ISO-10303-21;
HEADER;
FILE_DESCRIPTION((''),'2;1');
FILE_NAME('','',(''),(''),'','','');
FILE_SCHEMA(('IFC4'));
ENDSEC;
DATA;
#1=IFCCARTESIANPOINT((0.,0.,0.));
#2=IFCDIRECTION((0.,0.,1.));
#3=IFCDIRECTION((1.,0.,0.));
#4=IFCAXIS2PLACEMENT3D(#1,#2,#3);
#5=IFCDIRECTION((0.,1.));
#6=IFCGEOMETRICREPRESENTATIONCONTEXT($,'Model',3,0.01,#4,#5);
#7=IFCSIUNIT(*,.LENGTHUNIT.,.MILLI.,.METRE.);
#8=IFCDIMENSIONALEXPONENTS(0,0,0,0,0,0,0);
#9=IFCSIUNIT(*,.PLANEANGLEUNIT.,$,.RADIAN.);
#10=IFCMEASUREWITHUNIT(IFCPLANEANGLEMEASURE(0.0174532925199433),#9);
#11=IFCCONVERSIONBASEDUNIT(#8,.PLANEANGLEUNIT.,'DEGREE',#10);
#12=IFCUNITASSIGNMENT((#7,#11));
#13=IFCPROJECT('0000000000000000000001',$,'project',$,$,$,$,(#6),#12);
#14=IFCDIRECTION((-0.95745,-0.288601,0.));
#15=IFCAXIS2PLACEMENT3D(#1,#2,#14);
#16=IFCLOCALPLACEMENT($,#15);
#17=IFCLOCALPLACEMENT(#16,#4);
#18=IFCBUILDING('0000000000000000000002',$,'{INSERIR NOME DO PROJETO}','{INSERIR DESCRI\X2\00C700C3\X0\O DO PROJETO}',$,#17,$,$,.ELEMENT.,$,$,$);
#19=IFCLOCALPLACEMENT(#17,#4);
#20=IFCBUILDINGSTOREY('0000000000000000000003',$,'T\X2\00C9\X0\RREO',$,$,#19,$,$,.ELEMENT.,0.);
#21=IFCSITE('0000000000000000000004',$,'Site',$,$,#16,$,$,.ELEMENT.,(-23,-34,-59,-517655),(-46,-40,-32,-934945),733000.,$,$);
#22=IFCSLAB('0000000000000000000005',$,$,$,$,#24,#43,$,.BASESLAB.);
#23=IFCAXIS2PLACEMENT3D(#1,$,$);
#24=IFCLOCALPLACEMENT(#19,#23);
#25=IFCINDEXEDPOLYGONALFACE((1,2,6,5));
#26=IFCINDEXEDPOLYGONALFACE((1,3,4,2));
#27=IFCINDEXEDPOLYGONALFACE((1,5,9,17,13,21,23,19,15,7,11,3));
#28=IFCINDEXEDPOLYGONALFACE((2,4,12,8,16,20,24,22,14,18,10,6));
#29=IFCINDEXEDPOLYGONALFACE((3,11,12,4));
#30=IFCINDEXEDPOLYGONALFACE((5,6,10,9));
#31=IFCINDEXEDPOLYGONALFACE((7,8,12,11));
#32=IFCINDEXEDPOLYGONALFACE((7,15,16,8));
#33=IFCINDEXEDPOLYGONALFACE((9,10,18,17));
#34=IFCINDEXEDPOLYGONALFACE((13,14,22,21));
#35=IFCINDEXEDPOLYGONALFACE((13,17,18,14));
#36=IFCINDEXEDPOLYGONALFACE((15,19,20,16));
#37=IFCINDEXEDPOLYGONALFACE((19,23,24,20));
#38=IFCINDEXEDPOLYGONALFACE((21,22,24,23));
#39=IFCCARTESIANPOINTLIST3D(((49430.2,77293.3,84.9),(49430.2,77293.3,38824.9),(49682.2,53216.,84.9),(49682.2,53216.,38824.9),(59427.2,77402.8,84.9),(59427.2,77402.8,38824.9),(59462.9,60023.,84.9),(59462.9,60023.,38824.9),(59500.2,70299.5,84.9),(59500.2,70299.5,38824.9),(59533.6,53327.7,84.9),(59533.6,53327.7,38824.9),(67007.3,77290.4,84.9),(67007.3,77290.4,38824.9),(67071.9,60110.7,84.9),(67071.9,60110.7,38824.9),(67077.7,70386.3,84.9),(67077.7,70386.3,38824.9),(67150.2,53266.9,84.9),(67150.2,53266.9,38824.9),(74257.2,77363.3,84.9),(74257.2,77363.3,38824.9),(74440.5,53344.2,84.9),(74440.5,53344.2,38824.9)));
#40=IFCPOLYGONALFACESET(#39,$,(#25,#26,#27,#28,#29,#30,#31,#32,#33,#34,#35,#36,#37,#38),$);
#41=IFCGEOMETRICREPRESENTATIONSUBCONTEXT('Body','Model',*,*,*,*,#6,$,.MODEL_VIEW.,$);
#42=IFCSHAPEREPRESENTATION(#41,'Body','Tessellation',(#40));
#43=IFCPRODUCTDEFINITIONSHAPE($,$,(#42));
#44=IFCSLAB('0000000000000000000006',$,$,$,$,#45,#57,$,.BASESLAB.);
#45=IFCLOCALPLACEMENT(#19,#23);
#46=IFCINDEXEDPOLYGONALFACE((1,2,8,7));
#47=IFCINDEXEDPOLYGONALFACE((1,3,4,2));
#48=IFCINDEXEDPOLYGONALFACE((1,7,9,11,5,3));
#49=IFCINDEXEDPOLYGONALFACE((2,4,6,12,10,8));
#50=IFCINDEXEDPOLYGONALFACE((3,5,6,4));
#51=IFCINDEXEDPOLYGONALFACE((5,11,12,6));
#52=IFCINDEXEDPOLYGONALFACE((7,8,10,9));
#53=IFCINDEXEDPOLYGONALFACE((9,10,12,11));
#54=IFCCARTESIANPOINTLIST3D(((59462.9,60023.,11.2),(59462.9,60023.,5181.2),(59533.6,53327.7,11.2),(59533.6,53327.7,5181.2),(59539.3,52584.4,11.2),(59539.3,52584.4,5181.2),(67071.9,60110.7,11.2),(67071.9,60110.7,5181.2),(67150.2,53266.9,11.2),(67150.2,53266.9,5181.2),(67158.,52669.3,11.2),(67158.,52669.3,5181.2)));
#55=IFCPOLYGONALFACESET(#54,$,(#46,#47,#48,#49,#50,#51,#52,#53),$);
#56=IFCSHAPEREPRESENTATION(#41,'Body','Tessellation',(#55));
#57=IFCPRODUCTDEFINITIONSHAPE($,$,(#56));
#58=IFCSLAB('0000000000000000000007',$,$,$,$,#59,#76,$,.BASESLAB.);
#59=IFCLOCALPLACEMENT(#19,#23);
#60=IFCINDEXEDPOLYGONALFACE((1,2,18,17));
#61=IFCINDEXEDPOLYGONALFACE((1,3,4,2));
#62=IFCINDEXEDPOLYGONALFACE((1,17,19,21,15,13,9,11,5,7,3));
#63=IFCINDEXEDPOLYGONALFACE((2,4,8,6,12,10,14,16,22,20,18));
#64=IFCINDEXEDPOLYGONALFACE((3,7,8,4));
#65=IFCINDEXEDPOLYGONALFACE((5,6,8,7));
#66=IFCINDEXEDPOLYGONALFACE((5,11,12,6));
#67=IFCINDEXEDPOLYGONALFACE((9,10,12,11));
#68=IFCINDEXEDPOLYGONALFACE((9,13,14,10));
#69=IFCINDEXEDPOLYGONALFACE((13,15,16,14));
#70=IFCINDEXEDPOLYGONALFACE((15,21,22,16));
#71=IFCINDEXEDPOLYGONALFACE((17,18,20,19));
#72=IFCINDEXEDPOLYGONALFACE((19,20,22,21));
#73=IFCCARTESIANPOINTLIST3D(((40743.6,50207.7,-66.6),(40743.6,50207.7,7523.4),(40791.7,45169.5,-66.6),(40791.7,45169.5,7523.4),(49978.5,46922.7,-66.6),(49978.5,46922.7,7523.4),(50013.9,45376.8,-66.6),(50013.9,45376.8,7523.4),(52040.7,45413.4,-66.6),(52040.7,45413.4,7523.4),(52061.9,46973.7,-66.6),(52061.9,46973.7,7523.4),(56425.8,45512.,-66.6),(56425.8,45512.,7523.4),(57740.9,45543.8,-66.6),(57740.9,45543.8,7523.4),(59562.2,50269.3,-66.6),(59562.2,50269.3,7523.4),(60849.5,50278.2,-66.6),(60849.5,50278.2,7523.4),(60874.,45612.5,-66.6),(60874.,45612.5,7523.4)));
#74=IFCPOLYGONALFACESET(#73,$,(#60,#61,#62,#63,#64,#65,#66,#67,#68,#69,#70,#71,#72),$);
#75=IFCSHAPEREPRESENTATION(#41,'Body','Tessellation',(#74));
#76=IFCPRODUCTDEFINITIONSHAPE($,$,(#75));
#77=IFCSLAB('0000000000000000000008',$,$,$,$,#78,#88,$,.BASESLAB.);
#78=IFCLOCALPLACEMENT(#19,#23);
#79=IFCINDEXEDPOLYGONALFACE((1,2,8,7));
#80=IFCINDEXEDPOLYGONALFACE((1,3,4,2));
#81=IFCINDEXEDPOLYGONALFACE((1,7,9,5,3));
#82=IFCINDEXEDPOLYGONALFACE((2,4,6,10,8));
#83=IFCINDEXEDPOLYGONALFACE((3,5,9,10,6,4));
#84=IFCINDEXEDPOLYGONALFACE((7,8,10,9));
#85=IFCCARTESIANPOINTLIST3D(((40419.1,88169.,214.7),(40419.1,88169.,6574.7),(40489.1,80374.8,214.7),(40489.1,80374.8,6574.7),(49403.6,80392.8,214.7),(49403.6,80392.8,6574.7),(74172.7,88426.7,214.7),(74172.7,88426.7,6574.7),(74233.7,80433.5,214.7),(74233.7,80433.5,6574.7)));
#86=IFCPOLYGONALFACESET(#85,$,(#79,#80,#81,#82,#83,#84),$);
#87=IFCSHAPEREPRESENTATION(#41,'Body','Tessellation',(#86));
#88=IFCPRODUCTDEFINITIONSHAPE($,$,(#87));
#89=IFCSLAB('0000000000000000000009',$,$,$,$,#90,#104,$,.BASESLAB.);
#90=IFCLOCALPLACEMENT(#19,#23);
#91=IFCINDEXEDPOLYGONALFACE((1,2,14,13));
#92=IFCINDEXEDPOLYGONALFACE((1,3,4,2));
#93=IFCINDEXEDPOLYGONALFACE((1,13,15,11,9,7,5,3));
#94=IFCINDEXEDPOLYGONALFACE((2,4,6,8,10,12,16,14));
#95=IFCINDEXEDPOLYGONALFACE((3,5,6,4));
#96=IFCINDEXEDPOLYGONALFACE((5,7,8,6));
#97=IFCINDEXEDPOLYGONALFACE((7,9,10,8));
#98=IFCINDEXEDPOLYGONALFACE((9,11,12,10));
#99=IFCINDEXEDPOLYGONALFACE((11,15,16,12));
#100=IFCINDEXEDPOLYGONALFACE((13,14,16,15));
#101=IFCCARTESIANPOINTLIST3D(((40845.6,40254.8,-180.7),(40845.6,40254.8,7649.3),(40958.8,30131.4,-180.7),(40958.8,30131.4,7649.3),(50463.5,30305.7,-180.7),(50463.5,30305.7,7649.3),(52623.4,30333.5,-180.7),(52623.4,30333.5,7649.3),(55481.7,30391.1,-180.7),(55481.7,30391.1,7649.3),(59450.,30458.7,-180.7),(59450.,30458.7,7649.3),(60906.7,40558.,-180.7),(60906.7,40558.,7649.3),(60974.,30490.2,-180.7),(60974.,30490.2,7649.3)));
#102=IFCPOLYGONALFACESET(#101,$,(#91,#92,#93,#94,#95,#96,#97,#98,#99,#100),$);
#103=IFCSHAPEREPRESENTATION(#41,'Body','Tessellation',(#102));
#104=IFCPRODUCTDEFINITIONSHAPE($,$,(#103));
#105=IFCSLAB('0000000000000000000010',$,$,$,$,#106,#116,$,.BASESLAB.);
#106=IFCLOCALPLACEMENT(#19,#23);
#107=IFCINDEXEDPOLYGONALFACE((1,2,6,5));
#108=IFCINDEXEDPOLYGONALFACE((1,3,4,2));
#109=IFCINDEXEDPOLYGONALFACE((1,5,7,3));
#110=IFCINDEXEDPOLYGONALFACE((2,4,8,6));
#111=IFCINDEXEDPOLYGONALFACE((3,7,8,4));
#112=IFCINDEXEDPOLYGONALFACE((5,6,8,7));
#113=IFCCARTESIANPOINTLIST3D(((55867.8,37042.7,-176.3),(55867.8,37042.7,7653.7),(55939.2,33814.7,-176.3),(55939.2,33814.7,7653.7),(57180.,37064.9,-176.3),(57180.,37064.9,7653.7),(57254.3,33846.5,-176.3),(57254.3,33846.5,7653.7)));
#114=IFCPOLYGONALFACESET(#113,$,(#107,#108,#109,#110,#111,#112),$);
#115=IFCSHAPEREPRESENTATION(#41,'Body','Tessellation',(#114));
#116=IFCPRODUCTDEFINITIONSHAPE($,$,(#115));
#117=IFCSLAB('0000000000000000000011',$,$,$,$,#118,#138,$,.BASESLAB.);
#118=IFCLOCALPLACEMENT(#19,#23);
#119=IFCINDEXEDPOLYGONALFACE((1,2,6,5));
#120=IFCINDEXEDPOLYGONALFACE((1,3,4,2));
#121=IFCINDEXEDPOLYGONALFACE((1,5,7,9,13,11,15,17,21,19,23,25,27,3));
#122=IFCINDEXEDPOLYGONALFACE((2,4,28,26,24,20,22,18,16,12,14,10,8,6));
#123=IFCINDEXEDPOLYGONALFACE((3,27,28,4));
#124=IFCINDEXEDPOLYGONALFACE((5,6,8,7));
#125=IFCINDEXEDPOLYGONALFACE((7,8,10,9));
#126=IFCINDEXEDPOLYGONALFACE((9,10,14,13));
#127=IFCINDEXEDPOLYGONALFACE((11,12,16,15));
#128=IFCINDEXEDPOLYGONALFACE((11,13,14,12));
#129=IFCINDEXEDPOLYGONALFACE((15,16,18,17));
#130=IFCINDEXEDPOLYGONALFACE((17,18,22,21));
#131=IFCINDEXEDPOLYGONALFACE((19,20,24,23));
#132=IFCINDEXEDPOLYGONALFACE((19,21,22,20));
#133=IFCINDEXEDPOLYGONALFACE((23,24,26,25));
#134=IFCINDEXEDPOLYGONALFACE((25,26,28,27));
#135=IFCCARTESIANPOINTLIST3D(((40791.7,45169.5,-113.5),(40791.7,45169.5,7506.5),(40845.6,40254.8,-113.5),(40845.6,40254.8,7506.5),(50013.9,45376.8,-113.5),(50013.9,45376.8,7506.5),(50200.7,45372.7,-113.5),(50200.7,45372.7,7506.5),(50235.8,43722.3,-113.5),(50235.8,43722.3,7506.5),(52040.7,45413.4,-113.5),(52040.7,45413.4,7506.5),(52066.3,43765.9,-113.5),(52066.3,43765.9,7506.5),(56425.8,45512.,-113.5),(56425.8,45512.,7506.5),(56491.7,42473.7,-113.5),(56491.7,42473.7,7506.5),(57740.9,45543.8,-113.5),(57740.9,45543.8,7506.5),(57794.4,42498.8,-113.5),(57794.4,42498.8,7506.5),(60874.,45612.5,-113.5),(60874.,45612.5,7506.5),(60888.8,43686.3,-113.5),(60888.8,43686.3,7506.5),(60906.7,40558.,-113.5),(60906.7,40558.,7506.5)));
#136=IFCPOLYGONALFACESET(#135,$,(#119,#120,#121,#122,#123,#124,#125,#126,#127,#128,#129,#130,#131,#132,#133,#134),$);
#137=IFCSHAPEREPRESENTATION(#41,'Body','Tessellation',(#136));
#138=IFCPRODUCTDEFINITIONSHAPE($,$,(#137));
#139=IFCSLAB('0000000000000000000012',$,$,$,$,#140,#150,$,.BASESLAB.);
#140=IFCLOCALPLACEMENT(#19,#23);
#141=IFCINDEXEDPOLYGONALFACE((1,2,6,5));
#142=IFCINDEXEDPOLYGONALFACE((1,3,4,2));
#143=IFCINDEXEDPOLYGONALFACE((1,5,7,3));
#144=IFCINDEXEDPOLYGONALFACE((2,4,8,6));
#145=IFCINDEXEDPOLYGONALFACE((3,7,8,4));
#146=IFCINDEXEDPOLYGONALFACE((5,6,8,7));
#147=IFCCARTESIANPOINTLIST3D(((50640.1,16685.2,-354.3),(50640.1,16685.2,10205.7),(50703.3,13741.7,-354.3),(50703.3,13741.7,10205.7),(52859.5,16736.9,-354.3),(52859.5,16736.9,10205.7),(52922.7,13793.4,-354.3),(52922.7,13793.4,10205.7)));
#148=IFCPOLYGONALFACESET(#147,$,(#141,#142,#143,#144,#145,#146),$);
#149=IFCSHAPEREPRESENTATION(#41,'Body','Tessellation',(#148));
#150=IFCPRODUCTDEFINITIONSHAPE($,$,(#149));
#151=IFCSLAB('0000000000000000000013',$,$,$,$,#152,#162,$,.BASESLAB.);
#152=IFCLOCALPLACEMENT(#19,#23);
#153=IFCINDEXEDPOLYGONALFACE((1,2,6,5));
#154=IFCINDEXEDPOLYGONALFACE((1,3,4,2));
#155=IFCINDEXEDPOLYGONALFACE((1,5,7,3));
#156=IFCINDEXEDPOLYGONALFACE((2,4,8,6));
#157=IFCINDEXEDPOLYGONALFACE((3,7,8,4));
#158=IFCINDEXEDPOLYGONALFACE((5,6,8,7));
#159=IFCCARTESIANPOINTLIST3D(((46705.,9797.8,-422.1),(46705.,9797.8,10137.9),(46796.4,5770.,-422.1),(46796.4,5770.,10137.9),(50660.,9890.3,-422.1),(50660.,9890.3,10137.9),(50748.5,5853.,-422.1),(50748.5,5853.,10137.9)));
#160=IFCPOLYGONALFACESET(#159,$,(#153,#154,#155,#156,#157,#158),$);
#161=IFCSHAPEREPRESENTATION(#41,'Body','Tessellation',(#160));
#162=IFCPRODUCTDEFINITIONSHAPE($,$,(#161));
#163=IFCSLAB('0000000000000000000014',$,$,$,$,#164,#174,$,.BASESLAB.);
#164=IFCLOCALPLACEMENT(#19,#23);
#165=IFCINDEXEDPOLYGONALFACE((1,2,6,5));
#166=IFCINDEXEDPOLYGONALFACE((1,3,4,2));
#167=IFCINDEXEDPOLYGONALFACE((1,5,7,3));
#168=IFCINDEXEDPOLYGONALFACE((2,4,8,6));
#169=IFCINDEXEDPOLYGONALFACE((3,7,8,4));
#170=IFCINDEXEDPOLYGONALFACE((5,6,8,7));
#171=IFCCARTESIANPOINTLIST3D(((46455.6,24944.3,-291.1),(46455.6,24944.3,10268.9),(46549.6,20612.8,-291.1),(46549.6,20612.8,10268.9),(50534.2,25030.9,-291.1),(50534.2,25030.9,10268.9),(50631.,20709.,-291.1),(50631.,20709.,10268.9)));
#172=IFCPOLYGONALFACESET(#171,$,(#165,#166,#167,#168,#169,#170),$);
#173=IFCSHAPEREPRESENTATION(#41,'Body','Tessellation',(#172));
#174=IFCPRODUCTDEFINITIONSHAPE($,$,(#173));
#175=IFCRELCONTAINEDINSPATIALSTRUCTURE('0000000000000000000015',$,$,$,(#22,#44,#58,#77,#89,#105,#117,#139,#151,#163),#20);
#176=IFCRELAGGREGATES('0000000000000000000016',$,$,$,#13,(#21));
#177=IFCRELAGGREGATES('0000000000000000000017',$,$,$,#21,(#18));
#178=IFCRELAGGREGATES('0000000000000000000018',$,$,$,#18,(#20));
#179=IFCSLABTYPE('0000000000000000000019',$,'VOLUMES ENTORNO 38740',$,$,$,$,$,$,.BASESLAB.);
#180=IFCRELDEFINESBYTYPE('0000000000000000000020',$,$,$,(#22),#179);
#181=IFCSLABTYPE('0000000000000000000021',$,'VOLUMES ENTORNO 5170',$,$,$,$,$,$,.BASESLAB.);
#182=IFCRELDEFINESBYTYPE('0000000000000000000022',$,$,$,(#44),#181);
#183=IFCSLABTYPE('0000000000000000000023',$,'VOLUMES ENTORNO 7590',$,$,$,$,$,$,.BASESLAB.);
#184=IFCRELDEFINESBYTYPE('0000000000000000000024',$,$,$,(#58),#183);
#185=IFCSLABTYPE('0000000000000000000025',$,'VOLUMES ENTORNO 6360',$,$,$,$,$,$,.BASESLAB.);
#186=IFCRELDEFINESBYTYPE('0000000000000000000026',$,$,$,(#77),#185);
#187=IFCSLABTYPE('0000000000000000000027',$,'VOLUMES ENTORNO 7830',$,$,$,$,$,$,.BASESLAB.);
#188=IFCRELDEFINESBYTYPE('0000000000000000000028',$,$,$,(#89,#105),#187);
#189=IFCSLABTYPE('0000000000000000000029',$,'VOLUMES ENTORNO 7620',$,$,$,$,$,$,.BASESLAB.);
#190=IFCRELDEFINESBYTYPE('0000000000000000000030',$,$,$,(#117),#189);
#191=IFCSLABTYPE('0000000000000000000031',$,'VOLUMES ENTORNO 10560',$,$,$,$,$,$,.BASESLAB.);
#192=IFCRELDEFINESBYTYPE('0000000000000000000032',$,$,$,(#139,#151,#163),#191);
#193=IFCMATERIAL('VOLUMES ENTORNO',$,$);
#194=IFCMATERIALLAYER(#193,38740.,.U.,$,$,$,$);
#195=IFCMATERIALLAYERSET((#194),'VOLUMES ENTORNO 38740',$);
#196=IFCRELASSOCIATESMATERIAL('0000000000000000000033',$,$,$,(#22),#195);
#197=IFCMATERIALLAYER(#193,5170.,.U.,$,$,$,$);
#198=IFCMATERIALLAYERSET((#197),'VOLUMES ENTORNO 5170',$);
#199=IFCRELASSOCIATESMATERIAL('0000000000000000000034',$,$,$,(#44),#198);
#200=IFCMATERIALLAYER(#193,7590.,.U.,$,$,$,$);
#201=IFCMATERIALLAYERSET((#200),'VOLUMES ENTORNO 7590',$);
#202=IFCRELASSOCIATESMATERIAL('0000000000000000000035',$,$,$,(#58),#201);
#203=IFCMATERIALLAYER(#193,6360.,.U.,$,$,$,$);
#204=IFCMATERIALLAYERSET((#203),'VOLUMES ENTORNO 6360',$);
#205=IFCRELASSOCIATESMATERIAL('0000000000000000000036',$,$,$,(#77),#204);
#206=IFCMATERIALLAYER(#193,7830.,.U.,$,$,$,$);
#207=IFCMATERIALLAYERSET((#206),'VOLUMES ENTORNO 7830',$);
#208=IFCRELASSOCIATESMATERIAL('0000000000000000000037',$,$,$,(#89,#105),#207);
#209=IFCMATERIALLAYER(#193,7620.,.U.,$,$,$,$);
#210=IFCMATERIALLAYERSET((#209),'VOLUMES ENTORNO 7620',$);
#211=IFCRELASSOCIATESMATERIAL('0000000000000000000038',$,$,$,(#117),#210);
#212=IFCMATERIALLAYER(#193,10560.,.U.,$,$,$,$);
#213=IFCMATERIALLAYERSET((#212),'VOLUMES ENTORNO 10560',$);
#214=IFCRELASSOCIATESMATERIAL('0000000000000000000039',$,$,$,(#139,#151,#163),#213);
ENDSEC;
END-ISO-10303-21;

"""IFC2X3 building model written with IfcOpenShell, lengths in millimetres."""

from ifc_helpers import new_model, entity, si_unit, converted_unit, direction, frame, origin_with_axes, place, context, subcontext, project, spatial, polyline, outline, extrude, material, layer, layer_set, layer_usage, type_object, element, save


model = new_model("IFC2X3")

# Units and contexts
model_context = context("Model", 3, precision=0.01, world=origin_with_axes(), true_north=direction((0.0, 1.0)))
body_context = subcontext(model_context, "Body", "Model", "MODEL_VIEW")
ifc_project = project(units=[si_unit("LENGTHUNIT", "METRE", prefix="MILLI"), converted_unit("PLANEANGLEUNIT", "DEGREE", entity("IfcPlaneAngleMeasure", 0.0174532925199433), si_unit("PLANEANGLEUNIT", "RADIAN"), dimensions=[0, 0, 0, 0, 0, 0, 0])], contexts=[model_context])

# Site, building, storey
site_placement = place(None, frame((0.0, 0.0, 0.0), z_axis=(0.0, 0.0, 1.0), x_axis=(-0.95745, -0.288601, 0.0)))
site = spatial("IfcSite", under=ifc_project, at=site_placement, Name="Site", CompositionType="ELEMENT", RefLatitude=(-23, -34, -59, -517655), RefLongitude=(-46, -40, -32, -934945), RefElevation=733000.0)
building_placement = place(site_placement, origin_with_axes())
building = spatial("IfcBuilding", under=site, at=building_placement, Name="{INSERIR NOME DO PROJETO}", Description="{INSERIR DESCRIÇÃO DO PROJETO}", CompositionType="ELEMENT")
storey_placement = place(building_placement, origin_with_axes())
storey = spatial("IfcBuildingStorey", under=building, at=storey_placement, Name="TÉRREO", CompositionType="ELEMENT", Elevation=0.0)

# Slabs
ifc_material_1 = material(Name="VOLUMES ENTORNO")
ifc_layer_1 = layer(ifc_material_1, 38740.0, ventilated="UNKNOWN")
ifc_layer_set_1 = layer_set([ifc_layer_1], Name="VOLUMES ENTORNO 38740")
ifc_layer_usage_1 = layer_usage(ifc_layer_set_1, "AXIS3", "NEGATIVE", 38740.0)
slab_type_1 = type_object("IfcSlabType", Name="VOLUMES ENTORNO 38740", PredefinedType="BASESLAB")
slab_1_placement = place(storey_placement, frame((67071.9, 60110.7, 84.9), z_axis=(0.0, 0.0, 1.0), x_axis=(1.0, 0.0, 0.0)))
element("IfcSlab", 1, at=slab_1_placement, inside=storey, type_object=slab_type_1, material=ifc_layer_usage_1, PredefinedType="BASESLAB", context=body_context, shape_type="SweptSolid", body=[
    extrude(outline(polyline([(0.0, 0.0), (78.2, -6843.8), (7368.6, -6766.5), (7185.2, 17252.6), (-64.7, 17179.7), (5.8, 10275.6), (-7571.7, 10188.7), (-7644.8, 17292.1), (-17641.8, 17182.6), (-17389.8, -6894.7), (-7538.4, -6783.0), (-7609.1, -87.7), (0.0, 0.0)])), origin_with_axes(), (0.0, 0.0, 1.0), 38740.0),
])
ifc_layer_2 = layer(ifc_material_1, 5170.0, ventilated="UNKNOWN")
ifc_layer_set_2 = layer_set([ifc_layer_2], Name="VOLUMES ENTORNO 5170")
ifc_layer_usage_2 = layer_usage(ifc_layer_set_2, "AXIS3", "NEGATIVE", 5170.0)
slab_type_2 = type_object("IfcSlabType", Name="VOLUMES ENTORNO 5170", PredefinedType="BASESLAB")
slab_2_placement = place(storey_placement, frame((67071.9, 60110.7, 11.2), z_axis=(0.0, 0.0, 1.0), x_axis=(1.0, 0.0, 0.0)))
element("IfcSlab", 2, at=slab_2_placement, inside=storey, type_object=slab_type_2, material=ifc_layer_usage_2, PredefinedType="BASESLAB", context=body_context, shape_type="SweptSolid", body=[
    extrude(outline(polyline([(0.0, 0.0), (-7609.1, -87.7), (-7538.4, -6783.0), (-7532.6, -7526.3), (86.0, -7441.5), (78.2, -6843.8), (0.0, 0.0)])), origin_with_axes(), (0.0, 0.0, 1.0), 5170.0),
])
ifc_layer_3 = layer(ifc_material_1, 7590.0, ventilated="UNKNOWN")
ifc_layer_set_3 = layer_set([ifc_layer_3], Name="VOLUMES ENTORNO 7590")
ifc_layer_usage_3 = layer_usage(ifc_layer_set_3, "AXIS3", "NEGATIVE", 7590.0)
slab_type_3 = type_object("IfcSlabType", Name="VOLUMES ENTORNO 7590", PredefinedType="BASESLAB")
slab_3_placement = place(storey_placement, frame((50013.9, 45376.8, -66.6), z_axis=(0.0, 0.0, 1.0), x_axis=(1.0, 0.0, 0.0)))
element("IfcSlab", 3, at=slab_3_placement, inside=storey, type_object=slab_type_3, material=ifc_layer_usage_3, PredefinedType="BASESLAB", context=body_context, shape_type="SweptSolid", body=[
    extrude(outline(polyline([(0.0, 0.0), (-35.3, 1546.0), (2048.0, 1596.9), (2026.8, 36.6), (6411.9, 135.3), (7727.0, 167.1), (10860.2, 235.8), (10835.6, 4901.4), (9548.3, 4892.5), (-9270.2, 4831.0), (-9222.2, -207.3), (0.0, 0.0)])), origin_with_axes(), (0.0, 0.0, 1.0), 7590.0),
])
ifc_layer_4 = layer(ifc_material_1, 6360.0, ventilated="UNKNOWN")
ifc_layer_set_4 = layer_set([ifc_layer_4], Name="VOLUMES ENTORNO 6360")
ifc_layer_usage_4 = layer_usage(ifc_layer_set_4, "AXIS3", "NEGATIVE", 6360.0)
slab_type_4 = type_object("IfcSlabType", Name="VOLUMES ENTORNO 6360", PredefinedType="BASESLAB")
slab_4_placement = place(storey_placement, frame((40489.1, 80374.8, 214.7), z_axis=(0.0, 0.0, 1.0), x_axis=(1.0, 0.0, 0.0)))
element("IfcSlab", 4, at=slab_4_placement, inside=storey, type_object=slab_type_4, material=ifc_layer_usage_4, PredefinedType="BASESLAB", context=body_context, shape_type="SweptSolid", body=[
    extrude(outline(polyline([(0.0, 0.0), (8914.5, 18.0), (33744.7, 58.7), (33683.6, 8051.9), (-70.0, 7794.2), (0.0, 0.0)])), origin_with_axes(), (0.0, 0.0, 1.0), 6360.0),
])
ifc_layer_5 = layer(ifc_material_1, 7830.0, ventilated="UNKNOWN")
ifc_layer_set_5 = layer_set([ifc_layer_5], Name="VOLUMES ENTORNO 7830")
ifc_layer_usage_5 = layer_usage(ifc_layer_set_5, "AXIS3", "NEGATIVE", 7830.0)
slab_type_5 = type_object("IfcSlabType", Name="VOLUMES ENTORNO 7830", PredefinedType="BASESLAB")
slab_5_placement = place(storey_placement, frame((60974.0, 30490.2, -180.7), z_axis=(0.0, 0.0, 1.0), x_axis=(1.0, 0.0, 0.0)))
element("IfcSlab", 5, at=slab_5_placement, inside=storey, type_object=slab_type_5, material=ifc_layer_usage_5, PredefinedType="BASESLAB", context=body_context, shape_type="SweptSolid", body=[
    extrude(outline(polyline([(0.0, 0.0), (-67.3, 10067.8), (-20128.4, 9764.6), (-20015.2, -358.9), (-10510.5, -184.5), (-8350.5, -156.7), (-5492.3, -99.1), (-1523.9, -31.5), (0.0, 0.0)])), origin_with_axes(), (0.0, 0.0, 1.0), 7830.0),
])
ifc_layer_usage_6 = layer_usage(ifc_layer_set_5, "AXIS3", "NEGATIVE", 7830.0)
slab_6_placement = place(storey_placement, frame((55867.8, 37042.7, -176.3), z_axis=(0.0, 0.0, 1.0), x_axis=(1.0, 0.0, 0.0)))
element("IfcSlab", 6, at=slab_6_placement, inside=storey, type_object=slab_type_5, material=ifc_layer_usage_6, PredefinedType="BASESLAB", context=body_context, shape_type="SweptSolid", body=[
    extrude(outline(polyline([(0.0, 0.0), (71.4, -3228.0), (1386.6, -3196.2), (1312.3, 22.2), (0.0, 0.0)])), origin_with_axes(), (0.0, 0.0, 1.0), 7830.0),
])
ifc_layer_6 = layer(ifc_material_1, 7620.0, ventilated="UNKNOWN")
ifc_layer_set_6 = layer_set([ifc_layer_6], Name="VOLUMES ENTORNO 7620")
ifc_layer_usage_7 = layer_usage(ifc_layer_set_6, "AXIS3", "NEGATIVE", 7620.0)
slab_type_6 = type_object("IfcSlabType", Name="VOLUMES ENTORNO 7620", PredefinedType="BASESLAB")
slab_7_placement = place(storey_placement, frame((60874.0, 45612.5, -113.5), z_axis=(0.0, 0.0, 1.0), x_axis=(1.0, 0.0, 0.0)))
element("IfcSlab", 7, at=slab_7_placement, inside=storey, type_object=slab_type_6, material=ifc_layer_usage_7, PredefinedType="BASESLAB", context=body_context, shape_type="SweptSolid", body=[
    extrude(outline(polyline([(0.0, 0.0), (-3133.1, -68.7), (-3079.7, -3113.7), (-4382.3, -3138.8), (-4448.3, -100.5), (-8833.3, -199.2), (-8807.7, -1846.7), (-10638.2, -1890.2), (-10673.4, -239.9), (-10860.2, -235.8), (-20082.4, -443.1), (-20028.5, -5357.7), (32.7, -5054.5), (14.7, -1926.2), (0.0, 0.0)])), origin_with_axes(), (0.0, 0.0, 1.0), 7620.0),
])
ifc_layer_7 = layer(ifc_material_1, 10560.0, ventilated="UNKNOWN")
ifc_layer_set_7 = layer_set([ifc_layer_7], Name="VOLUMES ENTORNO 10560")
ifc_layer_usage_8 = layer_usage(ifc_layer_set_7, "AXIS3", "NEGATIVE", 10560.0)
slab_type_7 = type_object("IfcSlabType", Name="VOLUMES ENTORNO 10560", PredefinedType="BASESLAB")
slab_8_placement = place(storey_placement, frame((50640.1, 16685.2, -354.3), z_axis=(0.0, 0.0, 1.0), x_axis=(1.0, 0.0, 0.0)))
element("IfcSlab", 8, at=slab_8_placement, inside=storey, type_object=slab_type_7, material=ifc_layer_usage_8, PredefinedType="BASESLAB", context=body_context, shape_type="SweptSolid", body=[
    extrude(outline(polyline([(0.0, 0.0), (63.2, -2943.5), (2282.5, -2891.8), (2219.4, 51.7), (0.0, 0.0)])), origin_with_axes(), (0.0, 0.0, 1.0), 10560.0),
])
ifc_layer_usage_9 = layer_usage(ifc_layer_set_7, "AXIS3", "NEGATIVE", 10560.0)
slab_9_placement = place(storey_placement, frame((46705.0, 9797.8, -422.1), z_axis=(0.0, 0.0, 1.0), x_axis=(1.0, 0.0, 0.0)))
element("IfcSlab", 9, at=slab_9_placement, inside=storey, type_object=slab_type_7, material=ifc_layer_usage_9, PredefinedType="BASESLAB", context=body_context, shape_type="SweptSolid", body=[
    extrude(outline(polyline([(0.0, 0.0), (91.5, -4027.8), (4043.6, -3944.8), (3955.0, 92.5), (0.0, 0.0)])), origin_with_axes(), (0.0, 0.0, 1.0), 10560.0),
])
ifc_layer_usage_10 = layer_usage(ifc_layer_set_7, "AXIS3", "NEGATIVE", 10560.0)
slab_10_placement = place(storey_placement, frame((46455.6, 24944.3, -291.1), z_axis=(0.0, 0.0, 1.0), x_axis=(1.0, 0.0, 0.0)))
element("IfcSlab", 10, at=slab_10_placement, inside=storey, type_object=slab_type_7, material=ifc_layer_usage_10, PredefinedType="BASESLAB", context=body_context, shape_type="SweptSolid", body=[
    extrude(outline(polyline([(0.0, 0.0), (93.9, -4331.4), (4175.4, -4235.2), (4078.5, 86.6), (0.0, 0.0)])), origin_with_axes(), (0.0, 0.0, 1.0), 10560.0),
])

save(model, "model.ifc")
